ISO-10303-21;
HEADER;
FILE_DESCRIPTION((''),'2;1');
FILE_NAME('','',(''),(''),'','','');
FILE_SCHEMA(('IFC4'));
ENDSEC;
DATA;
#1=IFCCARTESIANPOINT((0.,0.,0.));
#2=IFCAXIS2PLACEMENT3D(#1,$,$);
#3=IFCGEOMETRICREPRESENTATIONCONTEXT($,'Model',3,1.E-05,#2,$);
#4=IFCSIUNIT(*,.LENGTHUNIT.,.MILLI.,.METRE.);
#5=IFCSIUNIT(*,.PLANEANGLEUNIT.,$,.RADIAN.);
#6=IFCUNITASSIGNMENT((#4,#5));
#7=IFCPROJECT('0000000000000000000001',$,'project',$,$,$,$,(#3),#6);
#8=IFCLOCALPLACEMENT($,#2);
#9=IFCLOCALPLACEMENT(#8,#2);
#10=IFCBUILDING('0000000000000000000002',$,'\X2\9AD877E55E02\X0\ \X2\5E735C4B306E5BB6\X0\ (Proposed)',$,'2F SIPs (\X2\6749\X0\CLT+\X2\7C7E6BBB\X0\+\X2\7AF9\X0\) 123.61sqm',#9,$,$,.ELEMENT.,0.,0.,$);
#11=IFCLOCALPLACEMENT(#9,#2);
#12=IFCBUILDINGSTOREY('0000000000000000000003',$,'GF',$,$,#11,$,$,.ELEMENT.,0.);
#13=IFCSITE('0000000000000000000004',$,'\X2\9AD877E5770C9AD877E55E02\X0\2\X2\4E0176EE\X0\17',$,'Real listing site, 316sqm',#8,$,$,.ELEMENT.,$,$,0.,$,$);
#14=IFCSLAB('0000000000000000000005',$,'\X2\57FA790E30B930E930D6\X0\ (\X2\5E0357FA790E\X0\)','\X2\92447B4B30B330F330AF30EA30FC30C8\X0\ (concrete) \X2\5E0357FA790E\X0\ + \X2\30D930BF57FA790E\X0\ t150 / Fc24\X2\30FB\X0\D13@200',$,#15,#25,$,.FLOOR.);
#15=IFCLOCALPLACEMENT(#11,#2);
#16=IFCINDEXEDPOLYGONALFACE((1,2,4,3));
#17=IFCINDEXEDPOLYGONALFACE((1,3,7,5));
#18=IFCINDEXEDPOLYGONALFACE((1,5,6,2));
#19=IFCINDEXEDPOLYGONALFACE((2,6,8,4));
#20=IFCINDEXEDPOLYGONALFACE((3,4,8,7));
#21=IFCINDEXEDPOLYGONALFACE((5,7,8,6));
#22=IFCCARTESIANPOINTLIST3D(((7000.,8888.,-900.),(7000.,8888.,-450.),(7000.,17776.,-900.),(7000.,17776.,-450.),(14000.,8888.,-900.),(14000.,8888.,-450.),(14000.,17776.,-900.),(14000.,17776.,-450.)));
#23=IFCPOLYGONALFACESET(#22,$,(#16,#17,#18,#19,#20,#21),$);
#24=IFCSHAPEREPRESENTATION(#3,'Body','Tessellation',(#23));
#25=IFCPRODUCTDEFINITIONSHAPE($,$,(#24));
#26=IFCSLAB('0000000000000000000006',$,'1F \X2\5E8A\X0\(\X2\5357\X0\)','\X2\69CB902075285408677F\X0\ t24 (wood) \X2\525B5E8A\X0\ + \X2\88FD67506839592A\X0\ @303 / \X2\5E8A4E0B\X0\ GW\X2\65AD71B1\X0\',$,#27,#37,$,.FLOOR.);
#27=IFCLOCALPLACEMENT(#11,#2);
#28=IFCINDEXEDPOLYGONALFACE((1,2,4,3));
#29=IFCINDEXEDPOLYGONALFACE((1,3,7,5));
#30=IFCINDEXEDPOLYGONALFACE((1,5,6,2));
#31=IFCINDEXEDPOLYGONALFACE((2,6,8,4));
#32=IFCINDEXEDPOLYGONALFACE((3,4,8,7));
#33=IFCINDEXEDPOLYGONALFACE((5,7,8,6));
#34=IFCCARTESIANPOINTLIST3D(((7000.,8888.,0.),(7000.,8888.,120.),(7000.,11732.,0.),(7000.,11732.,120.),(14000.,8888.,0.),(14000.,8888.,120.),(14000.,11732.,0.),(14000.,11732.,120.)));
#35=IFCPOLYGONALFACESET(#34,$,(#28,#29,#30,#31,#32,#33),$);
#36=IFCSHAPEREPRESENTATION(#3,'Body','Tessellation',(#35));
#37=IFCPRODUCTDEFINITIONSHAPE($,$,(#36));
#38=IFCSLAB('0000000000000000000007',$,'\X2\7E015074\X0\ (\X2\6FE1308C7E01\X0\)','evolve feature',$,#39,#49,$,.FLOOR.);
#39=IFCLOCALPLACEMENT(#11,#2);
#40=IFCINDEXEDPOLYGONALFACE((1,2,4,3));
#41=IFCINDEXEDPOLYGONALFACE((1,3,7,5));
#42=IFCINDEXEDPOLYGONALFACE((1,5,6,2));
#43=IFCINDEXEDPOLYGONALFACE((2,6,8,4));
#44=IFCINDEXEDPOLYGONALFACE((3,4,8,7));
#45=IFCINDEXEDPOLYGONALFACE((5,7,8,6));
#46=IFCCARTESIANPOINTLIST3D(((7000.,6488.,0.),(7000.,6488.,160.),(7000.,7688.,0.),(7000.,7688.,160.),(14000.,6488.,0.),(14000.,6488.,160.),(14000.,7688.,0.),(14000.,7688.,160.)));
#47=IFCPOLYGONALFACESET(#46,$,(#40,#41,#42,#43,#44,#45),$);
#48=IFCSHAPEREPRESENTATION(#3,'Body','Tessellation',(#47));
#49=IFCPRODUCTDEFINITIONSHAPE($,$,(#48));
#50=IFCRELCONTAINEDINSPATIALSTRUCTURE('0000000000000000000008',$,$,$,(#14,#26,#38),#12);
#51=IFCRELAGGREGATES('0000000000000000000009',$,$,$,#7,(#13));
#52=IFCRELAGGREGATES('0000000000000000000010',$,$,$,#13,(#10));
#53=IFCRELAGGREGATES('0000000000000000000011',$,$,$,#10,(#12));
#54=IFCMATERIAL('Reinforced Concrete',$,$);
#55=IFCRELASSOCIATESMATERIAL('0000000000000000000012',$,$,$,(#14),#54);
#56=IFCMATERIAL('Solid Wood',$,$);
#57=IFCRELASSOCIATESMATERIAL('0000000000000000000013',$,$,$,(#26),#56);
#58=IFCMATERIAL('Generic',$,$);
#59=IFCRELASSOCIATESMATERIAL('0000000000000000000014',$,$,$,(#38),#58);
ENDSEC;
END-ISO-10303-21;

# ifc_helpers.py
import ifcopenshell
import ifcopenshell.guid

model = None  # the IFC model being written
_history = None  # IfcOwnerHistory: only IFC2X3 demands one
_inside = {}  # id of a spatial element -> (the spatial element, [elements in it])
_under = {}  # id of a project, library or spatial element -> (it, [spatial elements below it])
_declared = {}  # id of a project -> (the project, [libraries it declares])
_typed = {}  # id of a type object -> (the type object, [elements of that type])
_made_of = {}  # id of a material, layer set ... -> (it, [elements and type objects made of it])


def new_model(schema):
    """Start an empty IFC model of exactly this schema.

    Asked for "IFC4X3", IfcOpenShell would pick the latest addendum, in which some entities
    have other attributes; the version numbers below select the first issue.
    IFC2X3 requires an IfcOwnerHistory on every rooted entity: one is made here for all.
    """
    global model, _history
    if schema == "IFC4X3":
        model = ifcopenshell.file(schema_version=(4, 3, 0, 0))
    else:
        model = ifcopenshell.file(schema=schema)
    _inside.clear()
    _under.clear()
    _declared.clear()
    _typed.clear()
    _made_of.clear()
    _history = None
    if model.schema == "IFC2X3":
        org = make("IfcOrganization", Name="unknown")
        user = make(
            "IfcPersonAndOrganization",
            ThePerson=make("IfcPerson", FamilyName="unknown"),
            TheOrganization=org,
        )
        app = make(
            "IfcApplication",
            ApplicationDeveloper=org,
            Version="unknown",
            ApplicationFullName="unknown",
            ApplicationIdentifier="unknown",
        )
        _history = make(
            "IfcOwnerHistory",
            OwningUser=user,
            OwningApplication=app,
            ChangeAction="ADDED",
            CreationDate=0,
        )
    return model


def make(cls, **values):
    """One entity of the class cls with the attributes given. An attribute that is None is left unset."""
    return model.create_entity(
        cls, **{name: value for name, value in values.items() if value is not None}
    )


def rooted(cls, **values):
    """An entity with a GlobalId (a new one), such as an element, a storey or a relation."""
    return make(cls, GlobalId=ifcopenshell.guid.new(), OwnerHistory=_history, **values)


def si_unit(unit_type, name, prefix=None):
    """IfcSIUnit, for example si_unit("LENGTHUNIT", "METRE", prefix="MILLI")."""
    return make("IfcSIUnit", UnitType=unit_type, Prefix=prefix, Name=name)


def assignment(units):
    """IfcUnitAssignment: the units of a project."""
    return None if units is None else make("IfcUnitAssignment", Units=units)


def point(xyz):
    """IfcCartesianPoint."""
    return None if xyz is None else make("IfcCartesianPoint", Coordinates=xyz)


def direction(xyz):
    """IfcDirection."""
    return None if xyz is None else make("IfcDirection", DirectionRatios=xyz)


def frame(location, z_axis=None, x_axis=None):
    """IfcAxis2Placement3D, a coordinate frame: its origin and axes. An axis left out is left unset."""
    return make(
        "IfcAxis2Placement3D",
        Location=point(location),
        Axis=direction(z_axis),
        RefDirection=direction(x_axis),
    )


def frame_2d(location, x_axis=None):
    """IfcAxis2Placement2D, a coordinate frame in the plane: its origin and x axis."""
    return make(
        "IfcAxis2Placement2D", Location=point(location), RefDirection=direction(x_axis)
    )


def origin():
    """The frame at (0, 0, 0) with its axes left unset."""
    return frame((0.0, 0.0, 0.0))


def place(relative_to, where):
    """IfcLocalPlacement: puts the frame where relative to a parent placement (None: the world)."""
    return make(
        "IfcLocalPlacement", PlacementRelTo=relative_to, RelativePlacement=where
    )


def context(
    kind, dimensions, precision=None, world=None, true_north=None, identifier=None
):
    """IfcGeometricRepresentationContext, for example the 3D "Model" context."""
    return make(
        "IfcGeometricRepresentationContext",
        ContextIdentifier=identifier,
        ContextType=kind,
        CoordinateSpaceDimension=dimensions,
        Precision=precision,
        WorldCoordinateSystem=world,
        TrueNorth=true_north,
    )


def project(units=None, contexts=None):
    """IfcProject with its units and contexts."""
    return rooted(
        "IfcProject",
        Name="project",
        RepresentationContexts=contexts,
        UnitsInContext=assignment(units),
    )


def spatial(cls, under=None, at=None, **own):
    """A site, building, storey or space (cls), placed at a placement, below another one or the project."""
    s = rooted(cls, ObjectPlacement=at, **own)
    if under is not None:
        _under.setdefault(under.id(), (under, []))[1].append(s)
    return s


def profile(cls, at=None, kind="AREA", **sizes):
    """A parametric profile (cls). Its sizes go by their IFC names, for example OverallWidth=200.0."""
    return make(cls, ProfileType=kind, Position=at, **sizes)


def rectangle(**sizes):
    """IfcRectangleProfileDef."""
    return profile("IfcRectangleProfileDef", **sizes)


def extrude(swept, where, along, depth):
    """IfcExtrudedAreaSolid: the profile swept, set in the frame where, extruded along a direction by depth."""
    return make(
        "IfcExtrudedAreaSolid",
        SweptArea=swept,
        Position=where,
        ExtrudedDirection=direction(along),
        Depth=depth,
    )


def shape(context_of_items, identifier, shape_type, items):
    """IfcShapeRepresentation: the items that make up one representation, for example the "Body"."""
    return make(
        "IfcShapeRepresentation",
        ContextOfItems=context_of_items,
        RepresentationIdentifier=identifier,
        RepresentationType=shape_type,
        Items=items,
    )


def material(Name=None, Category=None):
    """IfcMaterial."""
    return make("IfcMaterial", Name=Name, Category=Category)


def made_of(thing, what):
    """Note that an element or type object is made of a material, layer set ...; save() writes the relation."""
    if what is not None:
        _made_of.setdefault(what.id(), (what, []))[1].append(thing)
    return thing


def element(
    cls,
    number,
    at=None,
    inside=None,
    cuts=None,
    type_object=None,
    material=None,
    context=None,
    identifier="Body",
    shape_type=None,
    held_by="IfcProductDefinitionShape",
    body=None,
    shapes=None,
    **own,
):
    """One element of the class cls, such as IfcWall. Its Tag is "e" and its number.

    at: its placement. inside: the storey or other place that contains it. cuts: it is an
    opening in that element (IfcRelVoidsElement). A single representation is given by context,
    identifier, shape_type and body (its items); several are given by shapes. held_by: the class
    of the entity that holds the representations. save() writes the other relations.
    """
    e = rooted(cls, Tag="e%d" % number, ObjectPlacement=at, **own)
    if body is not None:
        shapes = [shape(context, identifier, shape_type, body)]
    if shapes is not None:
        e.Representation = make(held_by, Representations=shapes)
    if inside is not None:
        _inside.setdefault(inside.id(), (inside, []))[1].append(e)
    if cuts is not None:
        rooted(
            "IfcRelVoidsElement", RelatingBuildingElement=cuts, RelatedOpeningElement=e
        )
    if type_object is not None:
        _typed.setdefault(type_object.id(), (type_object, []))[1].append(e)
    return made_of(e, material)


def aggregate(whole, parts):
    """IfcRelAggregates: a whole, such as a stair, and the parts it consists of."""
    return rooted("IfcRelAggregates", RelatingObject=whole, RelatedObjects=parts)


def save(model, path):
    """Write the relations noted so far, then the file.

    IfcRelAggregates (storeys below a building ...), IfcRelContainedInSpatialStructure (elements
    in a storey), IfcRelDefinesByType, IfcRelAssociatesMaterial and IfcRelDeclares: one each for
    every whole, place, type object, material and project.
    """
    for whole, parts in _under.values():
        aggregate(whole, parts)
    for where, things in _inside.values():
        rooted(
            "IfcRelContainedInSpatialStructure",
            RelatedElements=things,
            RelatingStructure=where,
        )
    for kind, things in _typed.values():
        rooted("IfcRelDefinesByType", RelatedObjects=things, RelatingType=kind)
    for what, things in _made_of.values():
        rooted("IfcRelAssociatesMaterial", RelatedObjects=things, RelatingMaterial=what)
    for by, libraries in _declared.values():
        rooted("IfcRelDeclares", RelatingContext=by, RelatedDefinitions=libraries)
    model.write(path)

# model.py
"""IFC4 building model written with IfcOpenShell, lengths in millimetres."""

from ifc_helpers import new_model, si_unit, frame, frame_2d, origin, place, context, project, spatial, rectangle, extrude, material, element, save


model = new_model("IFC4")

# Units and contexts
model_context = context("Model", 3, precision=1e-05, world=origin())
ifc_project = project(units=[si_unit("LENGTHUNIT", "METRE", prefix="MILLI"), si_unit("PLANEANGLEUNIT", "RADIAN")], contexts=[model_context])

# Site, building, storey
site_placement = place(None, origin())
site = spatial("IfcSite", under=ifc_project, at=site_placement, Name="高知県高知市2丁目17", ObjectType="Real listing site, 316sqm", CompositionType="ELEMENT", RefElevation=0.0)
building_placement = place(site_placement, origin())
building = spatial("IfcBuilding", under=site, at=building_placement, Name="高知市 平屋の家 (Proposed)", ObjectType="2F SIPs (杉CLT+籾殻+竹) 123.61sqm", CompositionType="ELEMENT", ElevationOfRefHeight=0.0, ElevationOfTerrain=0.0)
storey_placement = place(building_placement, origin())
storey = spatial("IfcBuildingStorey", under=building, at=storey_placement, Name="GF", CompositionType="ELEMENT", Elevation=0.0)

# Slabs
ifc_material_1 = material(Name="Reinforced Concrete")
slab_1_placement = place(storey_placement, frame((3500.0, 4444.0, -450.0)))
element("IfcSlab", 1, at=slab_1_placement, inside=storey, material=ifc_material_1, Name="基礎スラブ (布基礎)", Description="鉄筋コンクリート (concrete) 布基礎 + ベタ基礎 t150 / Fc24・D13@200", PredefinedType="FLOOR", context=model_context, shape_type="SweptSolid", body=[
    extrude(rectangle(XDim=7000.0, YDim=8888.0, at=frame_2d((3500.0, 4444.0))), frame((3500.0, 4444.0, -450.0)), (0.0, 0.0, 1.0), 450.0),
])
ifc_material_2 = material(Name="Solid Wood")
slab_2_placement = place(storey_placement, frame((3500.0, 4444.0, 0.0)))
element("IfcSlab", 2, at=slab_2_placement, inside=storey, material=ifc_material_2, Name="1F 床(南)", Description="構造用合板 t24 (wood) 剛床 + 製材根太 @303 / 床下 GW断熱", PredefinedType="FLOOR", context=model_context, shape_type="SweptSolid", body=[
    extrude(rectangle(XDim=7000.0, YDim=2844.0, at=frame_2d((3500.0, 1422.0))), frame((3500.0, 4444.0, 0.0)), (0.0, 0.0, 1.0), 120.0),
])
ifc_material_3 = material(Name="Generic")
slab_3_placement = place(storey_placement, frame((3500.0, 3244.0, 0.0)))
element("IfcSlab", 3, at=slab_3_placement, inside=storey, material=ifc_material_3, Name="縁側 (濡れ縁)", Description="evolve feature", PredefinedType="FLOOR", context=model_context, shape_type="SweptSolid", body=[
    extrude(rectangle(XDim=7000.0, YDim=1200.0, at=frame_2d((3500.0, 600.0))), frame((3500.0, 3244.0, 0.0)), (0.0, 0.0, 1.0), 160.0),
])

save(model, "model.ifc")
